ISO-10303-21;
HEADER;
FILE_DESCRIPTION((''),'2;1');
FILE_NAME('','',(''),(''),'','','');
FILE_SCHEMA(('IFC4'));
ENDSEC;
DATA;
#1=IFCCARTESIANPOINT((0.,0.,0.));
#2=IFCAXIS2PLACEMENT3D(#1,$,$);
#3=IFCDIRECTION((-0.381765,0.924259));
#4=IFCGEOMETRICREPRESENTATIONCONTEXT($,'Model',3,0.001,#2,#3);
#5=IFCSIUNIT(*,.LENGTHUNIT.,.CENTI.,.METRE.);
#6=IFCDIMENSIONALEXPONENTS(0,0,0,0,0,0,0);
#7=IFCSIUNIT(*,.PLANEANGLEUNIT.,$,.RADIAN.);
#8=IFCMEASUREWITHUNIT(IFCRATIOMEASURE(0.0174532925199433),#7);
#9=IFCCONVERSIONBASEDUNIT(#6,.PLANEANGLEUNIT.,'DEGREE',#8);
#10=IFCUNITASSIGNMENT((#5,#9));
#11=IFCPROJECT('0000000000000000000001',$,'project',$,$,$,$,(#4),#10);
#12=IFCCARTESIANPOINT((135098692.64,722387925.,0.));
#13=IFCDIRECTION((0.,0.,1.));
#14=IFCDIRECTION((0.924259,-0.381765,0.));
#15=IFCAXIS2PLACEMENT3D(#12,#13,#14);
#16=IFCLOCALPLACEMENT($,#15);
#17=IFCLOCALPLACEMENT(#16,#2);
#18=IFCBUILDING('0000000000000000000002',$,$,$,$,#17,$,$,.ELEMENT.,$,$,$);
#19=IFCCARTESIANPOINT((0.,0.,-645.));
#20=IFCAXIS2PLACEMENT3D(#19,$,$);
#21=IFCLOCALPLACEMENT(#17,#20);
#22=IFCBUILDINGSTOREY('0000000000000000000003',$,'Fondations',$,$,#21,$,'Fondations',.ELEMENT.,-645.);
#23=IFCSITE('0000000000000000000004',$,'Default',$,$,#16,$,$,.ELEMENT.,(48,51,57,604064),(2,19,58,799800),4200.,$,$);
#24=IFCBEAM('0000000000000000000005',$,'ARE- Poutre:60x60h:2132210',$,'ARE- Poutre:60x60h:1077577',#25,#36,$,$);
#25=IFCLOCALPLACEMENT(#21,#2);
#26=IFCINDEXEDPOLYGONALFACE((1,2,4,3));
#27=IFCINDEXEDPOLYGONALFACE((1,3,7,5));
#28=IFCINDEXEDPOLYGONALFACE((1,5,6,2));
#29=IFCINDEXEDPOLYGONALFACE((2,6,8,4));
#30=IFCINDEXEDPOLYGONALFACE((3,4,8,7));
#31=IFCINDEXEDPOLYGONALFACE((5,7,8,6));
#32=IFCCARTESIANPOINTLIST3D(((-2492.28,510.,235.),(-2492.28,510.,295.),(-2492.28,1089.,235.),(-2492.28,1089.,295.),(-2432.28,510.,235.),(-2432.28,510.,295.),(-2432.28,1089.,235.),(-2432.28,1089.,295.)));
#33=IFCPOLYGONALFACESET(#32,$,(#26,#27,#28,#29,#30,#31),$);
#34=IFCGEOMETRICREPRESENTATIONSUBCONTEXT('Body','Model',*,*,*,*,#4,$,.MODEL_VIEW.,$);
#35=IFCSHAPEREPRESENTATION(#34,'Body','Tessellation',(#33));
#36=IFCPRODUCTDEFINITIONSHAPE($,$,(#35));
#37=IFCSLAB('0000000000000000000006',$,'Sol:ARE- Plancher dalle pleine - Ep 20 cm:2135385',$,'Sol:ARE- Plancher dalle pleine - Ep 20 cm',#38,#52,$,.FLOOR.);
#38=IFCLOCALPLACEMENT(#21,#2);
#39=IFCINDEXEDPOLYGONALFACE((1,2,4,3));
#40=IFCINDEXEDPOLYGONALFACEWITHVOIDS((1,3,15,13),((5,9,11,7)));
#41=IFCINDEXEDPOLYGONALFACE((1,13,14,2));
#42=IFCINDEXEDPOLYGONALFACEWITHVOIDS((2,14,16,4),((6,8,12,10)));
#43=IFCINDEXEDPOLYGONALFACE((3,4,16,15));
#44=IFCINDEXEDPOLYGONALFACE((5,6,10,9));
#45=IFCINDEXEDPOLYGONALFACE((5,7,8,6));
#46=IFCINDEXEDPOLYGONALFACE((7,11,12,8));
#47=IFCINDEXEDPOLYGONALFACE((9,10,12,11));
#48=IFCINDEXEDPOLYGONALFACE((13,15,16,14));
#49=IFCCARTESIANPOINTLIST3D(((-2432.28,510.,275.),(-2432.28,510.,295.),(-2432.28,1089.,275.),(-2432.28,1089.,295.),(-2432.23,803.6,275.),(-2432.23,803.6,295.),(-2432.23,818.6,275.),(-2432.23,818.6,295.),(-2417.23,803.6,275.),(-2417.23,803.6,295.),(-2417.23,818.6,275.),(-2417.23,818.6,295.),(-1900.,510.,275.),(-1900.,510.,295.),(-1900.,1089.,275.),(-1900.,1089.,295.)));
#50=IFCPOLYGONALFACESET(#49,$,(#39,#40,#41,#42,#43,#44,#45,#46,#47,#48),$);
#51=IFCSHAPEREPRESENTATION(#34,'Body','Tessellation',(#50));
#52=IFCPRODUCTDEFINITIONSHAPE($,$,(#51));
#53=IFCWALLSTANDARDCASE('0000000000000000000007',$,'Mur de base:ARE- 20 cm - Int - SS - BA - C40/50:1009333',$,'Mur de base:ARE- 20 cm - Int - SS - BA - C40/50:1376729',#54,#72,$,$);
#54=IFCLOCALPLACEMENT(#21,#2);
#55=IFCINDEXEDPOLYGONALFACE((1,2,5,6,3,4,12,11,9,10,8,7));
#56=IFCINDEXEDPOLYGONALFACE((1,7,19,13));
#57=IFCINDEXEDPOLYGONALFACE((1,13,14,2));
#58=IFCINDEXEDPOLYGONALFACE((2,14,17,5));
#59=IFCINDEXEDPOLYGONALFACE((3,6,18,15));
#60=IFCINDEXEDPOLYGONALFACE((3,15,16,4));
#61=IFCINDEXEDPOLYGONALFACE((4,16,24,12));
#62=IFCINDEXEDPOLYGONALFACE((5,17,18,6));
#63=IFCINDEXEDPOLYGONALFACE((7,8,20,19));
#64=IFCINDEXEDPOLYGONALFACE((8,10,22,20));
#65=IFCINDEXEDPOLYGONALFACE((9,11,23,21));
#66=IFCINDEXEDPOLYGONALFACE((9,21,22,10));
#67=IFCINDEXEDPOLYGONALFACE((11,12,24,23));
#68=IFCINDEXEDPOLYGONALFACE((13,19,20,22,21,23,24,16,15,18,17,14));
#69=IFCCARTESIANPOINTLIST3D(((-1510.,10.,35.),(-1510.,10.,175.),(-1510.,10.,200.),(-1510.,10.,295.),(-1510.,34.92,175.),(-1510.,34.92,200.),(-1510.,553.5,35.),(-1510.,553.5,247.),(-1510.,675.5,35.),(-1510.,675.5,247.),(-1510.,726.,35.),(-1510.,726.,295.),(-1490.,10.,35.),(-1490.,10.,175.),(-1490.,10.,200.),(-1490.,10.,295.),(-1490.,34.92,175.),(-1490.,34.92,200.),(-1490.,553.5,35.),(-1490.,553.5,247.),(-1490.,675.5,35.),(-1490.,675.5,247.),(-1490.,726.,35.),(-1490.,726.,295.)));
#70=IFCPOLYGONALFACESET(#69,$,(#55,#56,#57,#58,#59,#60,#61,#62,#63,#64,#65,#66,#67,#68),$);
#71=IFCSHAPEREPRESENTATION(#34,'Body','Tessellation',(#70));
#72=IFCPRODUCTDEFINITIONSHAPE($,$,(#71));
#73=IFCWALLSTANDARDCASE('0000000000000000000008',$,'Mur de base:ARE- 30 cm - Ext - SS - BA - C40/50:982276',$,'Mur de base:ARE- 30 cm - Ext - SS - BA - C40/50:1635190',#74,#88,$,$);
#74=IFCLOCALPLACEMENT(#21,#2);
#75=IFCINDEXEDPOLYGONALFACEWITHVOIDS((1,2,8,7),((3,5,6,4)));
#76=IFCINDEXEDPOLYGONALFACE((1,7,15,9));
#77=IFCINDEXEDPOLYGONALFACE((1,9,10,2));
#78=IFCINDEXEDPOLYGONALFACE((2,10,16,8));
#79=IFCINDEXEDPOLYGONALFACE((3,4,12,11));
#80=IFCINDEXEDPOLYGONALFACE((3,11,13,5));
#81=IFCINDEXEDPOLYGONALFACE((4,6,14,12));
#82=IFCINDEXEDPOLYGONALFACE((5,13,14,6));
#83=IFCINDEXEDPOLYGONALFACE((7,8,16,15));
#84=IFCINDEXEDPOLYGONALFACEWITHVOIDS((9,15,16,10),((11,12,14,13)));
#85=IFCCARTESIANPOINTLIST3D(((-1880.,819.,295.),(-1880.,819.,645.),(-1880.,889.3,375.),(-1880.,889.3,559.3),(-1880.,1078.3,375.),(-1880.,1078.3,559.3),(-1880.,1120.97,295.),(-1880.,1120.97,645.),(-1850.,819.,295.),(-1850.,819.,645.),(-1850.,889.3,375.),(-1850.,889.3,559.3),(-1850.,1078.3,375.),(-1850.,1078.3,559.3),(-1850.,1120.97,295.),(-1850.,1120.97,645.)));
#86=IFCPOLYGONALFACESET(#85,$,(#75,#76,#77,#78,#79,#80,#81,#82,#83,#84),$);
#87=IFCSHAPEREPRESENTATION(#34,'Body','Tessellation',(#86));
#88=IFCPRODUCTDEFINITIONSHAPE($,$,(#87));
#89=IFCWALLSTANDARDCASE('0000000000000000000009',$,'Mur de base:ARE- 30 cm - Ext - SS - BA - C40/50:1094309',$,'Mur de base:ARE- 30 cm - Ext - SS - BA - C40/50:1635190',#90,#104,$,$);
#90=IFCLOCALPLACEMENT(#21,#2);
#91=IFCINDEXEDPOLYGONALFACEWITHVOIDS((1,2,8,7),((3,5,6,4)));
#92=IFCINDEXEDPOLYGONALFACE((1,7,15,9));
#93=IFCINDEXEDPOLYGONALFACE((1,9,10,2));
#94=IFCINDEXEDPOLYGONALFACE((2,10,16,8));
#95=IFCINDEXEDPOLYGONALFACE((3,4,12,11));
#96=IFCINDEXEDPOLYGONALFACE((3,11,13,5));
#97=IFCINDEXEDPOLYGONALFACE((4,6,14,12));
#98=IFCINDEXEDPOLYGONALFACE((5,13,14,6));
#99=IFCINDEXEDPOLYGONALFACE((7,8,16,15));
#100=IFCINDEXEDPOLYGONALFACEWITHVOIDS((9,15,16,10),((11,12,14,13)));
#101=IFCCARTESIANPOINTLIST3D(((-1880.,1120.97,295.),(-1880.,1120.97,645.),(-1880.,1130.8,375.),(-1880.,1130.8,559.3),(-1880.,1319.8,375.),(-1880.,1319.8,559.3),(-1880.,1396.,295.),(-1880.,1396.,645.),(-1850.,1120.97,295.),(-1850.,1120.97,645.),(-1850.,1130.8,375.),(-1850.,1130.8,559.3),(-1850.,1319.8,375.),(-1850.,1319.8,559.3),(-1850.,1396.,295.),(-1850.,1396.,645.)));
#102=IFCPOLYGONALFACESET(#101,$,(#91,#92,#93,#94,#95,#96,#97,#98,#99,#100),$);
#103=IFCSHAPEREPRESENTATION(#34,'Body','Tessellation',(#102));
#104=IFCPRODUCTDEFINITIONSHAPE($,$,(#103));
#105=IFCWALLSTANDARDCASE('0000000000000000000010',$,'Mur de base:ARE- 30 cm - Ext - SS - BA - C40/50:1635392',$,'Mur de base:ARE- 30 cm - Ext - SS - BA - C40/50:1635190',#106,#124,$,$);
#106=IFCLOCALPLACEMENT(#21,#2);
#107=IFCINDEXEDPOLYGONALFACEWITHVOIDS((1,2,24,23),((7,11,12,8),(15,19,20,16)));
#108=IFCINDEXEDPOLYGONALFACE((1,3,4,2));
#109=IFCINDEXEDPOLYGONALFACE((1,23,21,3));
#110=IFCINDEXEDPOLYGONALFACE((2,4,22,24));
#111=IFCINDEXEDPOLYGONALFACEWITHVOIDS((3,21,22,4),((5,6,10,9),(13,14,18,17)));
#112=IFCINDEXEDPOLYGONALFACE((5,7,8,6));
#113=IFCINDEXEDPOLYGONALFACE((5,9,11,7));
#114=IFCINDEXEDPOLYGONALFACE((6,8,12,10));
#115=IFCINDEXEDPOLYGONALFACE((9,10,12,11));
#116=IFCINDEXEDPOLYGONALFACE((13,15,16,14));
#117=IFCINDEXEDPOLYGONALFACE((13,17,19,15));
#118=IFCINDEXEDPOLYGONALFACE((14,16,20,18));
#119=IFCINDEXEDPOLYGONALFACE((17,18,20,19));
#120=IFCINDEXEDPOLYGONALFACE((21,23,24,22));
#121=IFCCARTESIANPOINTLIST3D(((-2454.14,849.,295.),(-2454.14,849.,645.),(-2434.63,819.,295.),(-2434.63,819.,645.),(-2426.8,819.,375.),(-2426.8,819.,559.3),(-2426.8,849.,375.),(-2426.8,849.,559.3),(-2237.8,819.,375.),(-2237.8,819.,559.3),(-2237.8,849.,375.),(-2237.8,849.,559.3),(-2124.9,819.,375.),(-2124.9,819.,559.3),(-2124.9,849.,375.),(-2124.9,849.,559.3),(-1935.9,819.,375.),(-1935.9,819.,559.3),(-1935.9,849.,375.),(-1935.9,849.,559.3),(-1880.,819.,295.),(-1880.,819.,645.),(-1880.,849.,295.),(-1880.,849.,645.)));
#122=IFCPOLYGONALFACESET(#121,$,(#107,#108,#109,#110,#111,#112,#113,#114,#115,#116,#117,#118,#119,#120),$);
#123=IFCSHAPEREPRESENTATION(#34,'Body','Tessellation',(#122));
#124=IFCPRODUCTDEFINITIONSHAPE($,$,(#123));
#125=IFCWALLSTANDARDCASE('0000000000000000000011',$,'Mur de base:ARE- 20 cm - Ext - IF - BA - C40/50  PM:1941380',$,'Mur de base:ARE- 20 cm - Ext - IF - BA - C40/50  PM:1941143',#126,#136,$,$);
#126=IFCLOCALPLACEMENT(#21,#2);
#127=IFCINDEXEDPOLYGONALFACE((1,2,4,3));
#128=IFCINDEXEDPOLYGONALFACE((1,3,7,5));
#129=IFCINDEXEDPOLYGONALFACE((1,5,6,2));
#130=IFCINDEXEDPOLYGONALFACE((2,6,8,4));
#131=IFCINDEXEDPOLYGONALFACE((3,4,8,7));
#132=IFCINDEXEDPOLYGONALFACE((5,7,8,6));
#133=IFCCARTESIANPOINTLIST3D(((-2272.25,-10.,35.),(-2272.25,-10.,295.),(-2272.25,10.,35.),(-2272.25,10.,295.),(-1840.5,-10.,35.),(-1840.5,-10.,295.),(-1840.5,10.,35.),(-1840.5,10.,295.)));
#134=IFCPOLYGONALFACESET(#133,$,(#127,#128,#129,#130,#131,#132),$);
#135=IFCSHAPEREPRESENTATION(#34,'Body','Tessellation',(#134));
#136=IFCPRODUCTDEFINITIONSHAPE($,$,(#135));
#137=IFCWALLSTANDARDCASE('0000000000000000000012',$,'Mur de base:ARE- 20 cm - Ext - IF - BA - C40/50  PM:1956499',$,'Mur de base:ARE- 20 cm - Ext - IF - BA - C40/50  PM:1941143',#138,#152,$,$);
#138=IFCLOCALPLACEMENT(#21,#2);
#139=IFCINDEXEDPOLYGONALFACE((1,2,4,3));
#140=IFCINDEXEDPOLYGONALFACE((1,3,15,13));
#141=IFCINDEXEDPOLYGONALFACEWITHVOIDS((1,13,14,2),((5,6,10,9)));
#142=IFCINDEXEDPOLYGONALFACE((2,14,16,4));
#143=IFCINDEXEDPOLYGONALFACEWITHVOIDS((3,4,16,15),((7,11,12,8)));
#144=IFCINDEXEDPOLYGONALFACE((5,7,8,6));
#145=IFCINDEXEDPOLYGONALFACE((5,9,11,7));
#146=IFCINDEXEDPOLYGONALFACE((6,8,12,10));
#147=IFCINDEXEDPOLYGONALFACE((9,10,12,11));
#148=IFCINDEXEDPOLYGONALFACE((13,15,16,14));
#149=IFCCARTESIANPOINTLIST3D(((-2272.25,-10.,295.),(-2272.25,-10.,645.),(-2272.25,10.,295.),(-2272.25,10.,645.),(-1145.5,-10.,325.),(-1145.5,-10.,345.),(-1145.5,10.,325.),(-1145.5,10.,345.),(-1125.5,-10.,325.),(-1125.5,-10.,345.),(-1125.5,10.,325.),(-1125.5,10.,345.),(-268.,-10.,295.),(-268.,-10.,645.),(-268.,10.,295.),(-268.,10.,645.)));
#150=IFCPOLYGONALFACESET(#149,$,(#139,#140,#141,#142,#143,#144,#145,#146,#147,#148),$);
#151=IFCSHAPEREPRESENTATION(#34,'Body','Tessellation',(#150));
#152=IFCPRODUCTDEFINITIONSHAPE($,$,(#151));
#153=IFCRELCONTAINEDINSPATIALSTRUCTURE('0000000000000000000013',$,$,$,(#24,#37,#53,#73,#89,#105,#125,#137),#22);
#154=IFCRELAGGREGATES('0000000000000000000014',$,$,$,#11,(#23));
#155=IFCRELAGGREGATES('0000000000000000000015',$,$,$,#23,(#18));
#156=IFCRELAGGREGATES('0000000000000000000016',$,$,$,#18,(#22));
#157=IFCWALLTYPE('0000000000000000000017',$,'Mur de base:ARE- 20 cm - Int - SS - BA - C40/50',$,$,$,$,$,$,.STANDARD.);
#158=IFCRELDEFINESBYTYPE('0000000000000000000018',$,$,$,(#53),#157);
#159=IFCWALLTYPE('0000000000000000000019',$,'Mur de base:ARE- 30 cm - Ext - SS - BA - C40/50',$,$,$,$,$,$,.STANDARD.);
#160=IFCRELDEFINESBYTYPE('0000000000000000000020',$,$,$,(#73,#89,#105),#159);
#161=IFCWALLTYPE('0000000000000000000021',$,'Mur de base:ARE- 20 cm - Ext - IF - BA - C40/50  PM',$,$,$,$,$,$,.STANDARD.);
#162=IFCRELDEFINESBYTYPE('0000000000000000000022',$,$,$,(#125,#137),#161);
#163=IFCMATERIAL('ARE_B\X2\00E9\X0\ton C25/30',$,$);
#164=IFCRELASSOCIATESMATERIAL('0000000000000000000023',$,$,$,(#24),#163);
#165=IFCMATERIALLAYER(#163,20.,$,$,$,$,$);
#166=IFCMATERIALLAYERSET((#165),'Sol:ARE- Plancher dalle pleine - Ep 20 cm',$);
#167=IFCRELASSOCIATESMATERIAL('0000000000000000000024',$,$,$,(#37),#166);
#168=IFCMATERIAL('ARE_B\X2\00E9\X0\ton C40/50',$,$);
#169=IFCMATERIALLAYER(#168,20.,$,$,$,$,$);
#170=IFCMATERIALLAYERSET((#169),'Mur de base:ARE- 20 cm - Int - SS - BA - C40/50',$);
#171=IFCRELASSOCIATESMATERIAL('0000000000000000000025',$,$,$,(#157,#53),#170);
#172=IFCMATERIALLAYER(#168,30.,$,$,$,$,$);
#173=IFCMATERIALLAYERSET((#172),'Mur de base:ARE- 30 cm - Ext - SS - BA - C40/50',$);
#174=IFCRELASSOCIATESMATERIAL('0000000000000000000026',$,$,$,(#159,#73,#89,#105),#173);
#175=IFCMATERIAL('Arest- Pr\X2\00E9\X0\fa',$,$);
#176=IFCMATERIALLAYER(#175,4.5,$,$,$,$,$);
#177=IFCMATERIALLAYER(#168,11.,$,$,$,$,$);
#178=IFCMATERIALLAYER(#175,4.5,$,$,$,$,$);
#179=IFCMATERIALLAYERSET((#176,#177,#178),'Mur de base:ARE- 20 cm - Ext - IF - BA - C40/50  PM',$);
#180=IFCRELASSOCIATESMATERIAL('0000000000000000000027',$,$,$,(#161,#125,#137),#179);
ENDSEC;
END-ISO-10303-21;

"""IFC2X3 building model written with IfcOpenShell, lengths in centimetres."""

from ifc_helpers import new_model, entity, si_unit, converted_unit, direction, frame, frame_2d, origin, origin_2d_with_axis, place, context, subcontext, project, spatial, polyline, rectangle, outline, extrude, material, layer, layer_set, layer_usage, type_object, element, save


model = new_model("IFC2X3")

# Units and contexts
model_context = context("Model", 3, precision=0.001, world=origin(), true_north=direction((-0.381765, 0.924259)))
body_context = subcontext(model_context, "Body", "Model", "MODEL_VIEW")
ifc_project = project(units=[si_unit("LENGTHUNIT", "METRE", prefix="CENTI"), converted_unit("PLANEANGLEUNIT", "DEGREE", entity("IfcRatioMeasure", 0.0174532925199433), si_unit("PLANEANGLEUNIT", "RADIAN"), dimensions=[0, 0, 0, 0, 0, 0, 0])], contexts=[model_context])

# Site, building, storey
site_placement = place(None, frame((135098692.64, 722387925.0, 0.0), z_axis=(0.0, 0.0, 1.0), x_axis=(0.924259, -0.381765, 0.0)))
site = spatial("IfcSite", under=ifc_project, at=site_placement, Name="Default", CompositionType="ELEMENT", RefLatitude=(48, 51, 57, 604064), RefLongitude=(2, 19, 58, 799800), RefElevation=4200.0)
building_placement = place(site_placement, origin())
building = spatial("IfcBuilding", under=site, at=building_placement, CompositionType="ELEMENT")
storey_placement = place(building_placement, frame((0.0, 0.0, -645.0)))
storey = spatial("IfcBuildingStorey", under=building, at=storey_placement, Name="Fondations", LongName="Fondations", CompositionType="ELEMENT", Elevation=-645.0)

# Beam
ifc_material_1 = material(Name="ARE_Béton C25/30")
beam_placement = place(storey_placement, frame((-2462.28, 480.0, 295.0), z_axis=(0.0, 0.0, 1.0), x_axis=(0.0, 1.0, 0.0)))
element("IfcBeam", 1, at=beam_placement, inside=storey, material=ifc_material_1, Name="ARE- Poutre:60x60h:2132210", ObjectType="ARE- Poutre:60x60h:1077577", context=body_context, shape_type="SweptSolid", body=[
    extrude(rectangle(XDim=60.0, YDim=60.0, at=origin_2d_with_axis()), frame((30.0, 0.0, -30.0), z_axis=(1.0, 0.0, 0.0), x_axis=(0.0, 0.0, -1.0)), (0.0, 0.0, 1.0), 579.0),
])

# Slab, opening
ifc_layer_1 = layer(ifc_material_1, 20.0)
ifc_layer_set_1 = layer_set([ifc_layer_1], Name="Sol:ARE- Plancher dalle pleine - Ep 20 cm")
ifc_layer_usage_1 = layer_usage(ifc_layer_set_1, "AXIS3", "POSITIVE", 0.0)
slab_placement = place(storey_placement, frame((-2432.28, 510.0, 275.0)))
slab = element("IfcSlab", 2, at=slab_placement, inside=storey, material=ifc_layer_usage_1, Name="Sol:ARE- Plancher dalle pleine - Ep 20 cm:2135385", ObjectType="Sol:ARE- Plancher dalle pleine - Ep 20 cm", PredefinedType="FLOOR", context=body_context, shape_type="SweptSolid", body=[
    extrude(rectangle(XDim=579.0, YDim=532.28, at=frame_2d((0.0, 0.0), x_axis=(0.0, -1.0))), frame((266.14, 289.5, 20.0), z_axis=(0.0, 0.0, -1.0), x_axis=(-1.0, 0.0, 0.0)), (0.0, 0.0, 1.0), 20.0),
])
opening_1_placement = place(slab_placement, origin())
element("IfcOpeningElement", 3, at=opening_1_placement, cuts=slab, ObjectType="Opening", context=body_context, shape_type="SweptSolid", body=[
    extrude(rectangle(XDim=15.0, YDim=15.0, at=origin_2d_with_axis()), frame((7.55, 301.1, 0.0), z_axis=(0.0, 0.0, 1.0), x_axis=(0.0, -1.0, 0.0)), (0.0, 0.0, 1.0), 20.0),
])

# Wall, openings
ifc_material_2 = material(Name="ARE_Béton C40/50")
ifc_layer_2 = layer(ifc_material_2, 20.0)
ifc_layer_set_2 = layer_set([ifc_layer_2], Name="Mur de base:ARE- 20 cm - Int - SS - BA - C40/50")
ifc_layer_usage_2 = layer_usage(ifc_layer_set_2, "AXIS2", "NEGATIVE", 10.0)
wall_type_1 = type_object("IfcWallType", Name="Mur de base:ARE- 20 cm - Int - SS - BA - C40/50", PredefinedType="STANDARD", material=ifc_layer_set_2)
wall_1_placement = place(storey_placement, frame((-1500.0, 10.0, 35.0), z_axis=(0.0, 0.0, 1.0), x_axis=(0.0, 1.0, 0.0)))
wall_1 = element("IfcWallStandardCase", 4, at=wall_1_placement, inside=storey, type_object=wall_type_1, material=ifc_layer_usage_2, Name="Mur de base:ARE- 20 cm - Int - SS - BA - C40/50:1009333", ObjectType="Mur de base:ARE- 20 cm - Int - SS - BA - C40/50:1376729", context=body_context, shape_type="SweptSolid", body=[
    extrude(rectangle(XDim=716.0, YDim=20.0, at=frame_2d((358.0, 0.0), x_axis=(-1.0, 0.0))), origin(), (0.0, 0.0, 1.0), 260.0),
])
opening_2_placement = place(wall_1_placement, origin())
element("IfcOpeningElement", 5, at=opening_2_placement, cuts=wall_1, ObjectType="Opening", context=body_context, shape_type="SweptSolid", body=[
    extrude(rectangle(XDim=25.0, YDim=25.0, at=frame_2d((0.0, 0.0), x_axis=(1.0, 0.0))), frame((12.42, -10.0, 152.5), z_axis=(0.0, 1.0, 0.0), x_axis=(0.0, 0.0, -1.0)), (0.0, 0.0, 1.0), 20.0),
])
opening_3_placement = place(wall_1_placement, frame((-10.0, -1500.0, -35.0), z_axis=(0.0, 0.0, 1.0), x_axis=(0.0, -1.0, 0.0)))
element("IfcOpeningElement", 6, at=opening_3_placement, cuts=wall_1, ObjectType="Opening", context=body_context, shape_type="SweptSolid", body=[
    extrude(rectangle(XDim=212.0, YDim=122.0, at=frame_2d((0.0, 0.0), x_axis=(0.0, 1.0))), frame((-1337.6, 614.5, 141.0), z_axis=(-1.0, 0.0, 0.0), x_axis=(0.0, 1.0, 0.0)), (0.0, 0.0, 1.0), 304.8),
])

# Walls, openings
ifc_layer_3 = layer(ifc_material_2, 30.0)
ifc_layer_set_3 = layer_set([ifc_layer_3], Name="Mur de base:ARE- 30 cm - Ext - SS - BA - C40/50")
ifc_layer_usage_3 = layer_usage(ifc_layer_set_3, "AXIS2", "NEGATIVE", 15.0)
wall_type_2 = type_object("IfcWallType", Name="Mur de base:ARE- 30 cm - Ext - SS - BA - C40/50", PredefinedType="STANDARD", material=ifc_layer_set_3)
wall_2_placement = place(storey_placement, frame((-1865.0, 819.0, 295.0), z_axis=(0.0, 0.0, 1.0), x_axis=(0.0, 1.0, 0.0)))
wall_2 = element("IfcWallStandardCase", 7, at=wall_2_placement, inside=storey, type_object=wall_type_2, material=ifc_layer_usage_3, Name="Mur de base:ARE- 30 cm - Ext - SS - BA - C40/50:982276", ObjectType="Mur de base:ARE- 30 cm - Ext - SS - BA - C40/50:1635190", context=body_context, shape_type="SweptSolid", body=[
    extrude(rectangle(XDim=301.97, YDim=30.0, at=frame_2d((150.98, 0.0), x_axis=(-1.0, 0.0))), origin(), (0.0, 0.0, 1.0), 350.0),
])
opening_4_placement = place(wall_2_placement, frame((-819.0, -1865.0, -295.0), z_axis=(0.0, 0.0, 1.0), x_axis=(0.0, -1.0, 0.0)))
element("IfcOpeningElement", 8, at=opening_4_placement, cuts=wall_2, ObjectType="Opening", context=body_context, shape_type="SweptSolid", body=[
    extrude(rectangle(XDim=184.3, YDim=189.0, at=frame_2d((0.0, 0.0), x_axis=(0.0, 1.0))), frame((-1697.6, 983.8, 467.15), z_axis=(-1.0, 0.0, 0.0), x_axis=(0.0, 1.0, 0.0)), (0.0, 0.0, 1.0), 304.8),
])
ifc_layer_usage_4 = layer_usage(ifc_layer_set_3, "AXIS2", "NEGATIVE", 15.0)
wall_3_placement = place(storey_placement, frame((-1865.0, 1120.97, 295.0), z_axis=(0.0, 0.0, 1.0), x_axis=(0.0, 1.0, 0.0)))
wall_3 = element("IfcWallStandardCase", 9, at=wall_3_placement, inside=storey, type_object=wall_type_2, material=ifc_layer_usage_4, Name="Mur de base:ARE- 30 cm - Ext - SS - BA - C40/50:1094309", ObjectType="Mur de base:ARE- 30 cm - Ext - SS - BA - C40/50:1635190", context=body_context, shape_type="SweptSolid", body=[
    extrude(rectangle(XDim=275.03, YDim=30.0, at=frame_2d((137.52, 0.0), x_axis=(-1.0, 0.0))), origin(), (0.0, 0.0, 1.0), 350.0),
])
opening_5_placement = place(wall_3_placement, frame((-1120.97, -1865.0, -295.0), z_axis=(0.0, 0.0, 1.0), x_axis=(0.0, -1.0, 0.0)))
element("IfcOpeningElement", 10, at=opening_5_placement, cuts=wall_3, ObjectType="Opening", context=body_context, shape_type="SweptSolid", body=[
    extrude(rectangle(XDim=184.3, YDim=189.0, at=frame_2d((0.0, 0.0), x_axis=(0.0, 1.0))), frame((-1697.6, 1225.3, 467.15), z_axis=(-1.0, 0.0, 0.0), x_axis=(0.0, 1.0, 0.0)), (0.0, 0.0, 1.0), 304.8),
])

# Wall, openings
ifc_layer_usage_5 = layer_usage(ifc_layer_set_3, "AXIS2", "NEGATIVE", 15.0)
wall_4_placement = place(storey_placement, frame((-2454.14, 834.0, 295.0)))
wall_4 = element("IfcWallStandardCase", 11, at=wall_4_placement, inside=storey, type_object=wall_type_2, material=ifc_layer_usage_5, Name="Mur de base:ARE- 30 cm - Ext - SS - BA - C40/50:1635392", ObjectType="Mur de base:ARE- 30 cm - Ext - SS - BA - C40/50:1635190", context=body_context, shape_type="SweptSolid", body=[
    extrude(outline(polyline([(574.14, -15.0), (574.14, 15.0), (0.0, 15.0), (19.51, -15.0), (574.14, -15.0)])), origin(), (0.0, 0.0, 1.0), 350.0),
])
opening_6_placement = place(wall_4_placement, frame((2454.14, -834.0, -295.0)))
element("IfcOpeningElement", 12, at=opening_6_placement, cuts=wall_4, ObjectType="Opening", context=body_context, shape_type="SweptSolid", body=[
    extrude(rectangle(XDim=184.3, YDim=189.0, at=frame_2d((0.0, 0.0), x_axis=(0.0, 1.0))), frame((-2030.4, 666.6, 467.15), z_axis=(0.0, 1.0, 0.0), x_axis=(1.0, 0.0, 0.0)), (0.0, 0.0, 1.0), 304.8),
])
opening_7_placement = place(wall_4_placement, frame((2454.14, -834.0, -295.0)))
element("IfcOpeningElement", 13, at=opening_7_placement, cuts=wall_4, ObjectType="Opening", context=body_context, shape_type="SweptSolid", body=[
    extrude(rectangle(XDim=184.3, YDim=189.0, at=frame_2d((0.0, 0.0), x_axis=(0.0, 1.0))), frame((-2332.3, 666.6, 467.15), z_axis=(0.0, 1.0, 0.0), x_axis=(1.0, 0.0, 0.0)), (0.0, 0.0, 1.0), 304.8),
])

# Wall
ifc_material_3 = material(Name="Arest- Préfa")
ifc_layer_4 = layer(ifc_material_3, 4.5)
ifc_layer_5 = layer(ifc_material_2, 11.0)
ifc_layer_6 = layer(ifc_material_3, 4.5)
ifc_layer_set_4 = layer_set([ifc_layer_4, ifc_layer_5, ifc_layer_6], Name="Mur de base:ARE- 20 cm - Ext - IF - BA - C40/50  PM")
ifc_layer_usage_6 = layer_usage(ifc_layer_set_4, "AXIS2", "NEGATIVE", 10.0)
wall_type_3 = type_object("IfcWallType", Name="Mur de base:ARE- 20 cm - Ext - IF - BA - C40/50  PM", PredefinedType="STANDARD", material=ifc_layer_set_4)
wall_5_placement = place(storey_placement, frame((-2272.25, 0.0, 35.0)))
element("IfcWallStandardCase", 14, at=wall_5_placement, inside=storey, type_object=wall_type_3, material=ifc_layer_usage_6, Name="Mur de base:ARE- 20 cm - Ext - IF - BA - C40/50  PM:1941380", ObjectType="Mur de base:ARE- 20 cm - Ext - IF - BA - C40/50  PM:1941143", context=body_context, shape_type="SweptSolid", body=[
    extrude(rectangle(XDim=431.75, YDim=20.0, at=frame_2d((215.88, 0.0), x_axis=(-1.0, 0.0))), origin(), (0.0, 0.0, 1.0), 260.0),
])

# Wall, opening
ifc_layer_usage_7 = layer_usage(ifc_layer_set_4, "AXIS2", "POSITIVE", -10.0)
wall_6_placement = place(storey_placement, frame((-2272.25, 0.0, 295.0)))
wall_6 = element("IfcWallStandardCase", 15, at=wall_6_placement, inside=storey, type_object=wall_type_3, material=ifc_layer_usage_7, Name="Mur de base:ARE- 20 cm - Ext - IF - BA - C40/50  PM:1956499", ObjectType="Mur de base:ARE- 20 cm - Ext - IF - BA - C40/50  PM:1941143", context=body_context, shape_type="SweptSolid", body=[
    extrude(rectangle(XDim=2004.25, YDim=20.0, at=frame_2d((1002.12, 0.0), x_axis=(-1.0, 0.0))), origin(), (0.0, 0.0, 1.0), 350.0),
])
opening_8_placement = place(wall_6_placement, origin())
element("IfcOpeningElement", 16, at=opening_8_placement, cuts=wall_6, ObjectType="Opening", context=body_context, shape_type="SweptSolid", body=[
    extrude(rectangle(XDim=20.0, YDim=20.0, at=frame_2d((0.0, 0.0), x_axis=(0.0, 1.0))), frame((1136.75, -10.0, 40.0), z_axis=(0.0, 1.0, 0.0), x_axis=(1.0, 0.0, 0.0)), (0.0, 0.0, 1.0), 20.0),
])

save(model, "model.ifc")
